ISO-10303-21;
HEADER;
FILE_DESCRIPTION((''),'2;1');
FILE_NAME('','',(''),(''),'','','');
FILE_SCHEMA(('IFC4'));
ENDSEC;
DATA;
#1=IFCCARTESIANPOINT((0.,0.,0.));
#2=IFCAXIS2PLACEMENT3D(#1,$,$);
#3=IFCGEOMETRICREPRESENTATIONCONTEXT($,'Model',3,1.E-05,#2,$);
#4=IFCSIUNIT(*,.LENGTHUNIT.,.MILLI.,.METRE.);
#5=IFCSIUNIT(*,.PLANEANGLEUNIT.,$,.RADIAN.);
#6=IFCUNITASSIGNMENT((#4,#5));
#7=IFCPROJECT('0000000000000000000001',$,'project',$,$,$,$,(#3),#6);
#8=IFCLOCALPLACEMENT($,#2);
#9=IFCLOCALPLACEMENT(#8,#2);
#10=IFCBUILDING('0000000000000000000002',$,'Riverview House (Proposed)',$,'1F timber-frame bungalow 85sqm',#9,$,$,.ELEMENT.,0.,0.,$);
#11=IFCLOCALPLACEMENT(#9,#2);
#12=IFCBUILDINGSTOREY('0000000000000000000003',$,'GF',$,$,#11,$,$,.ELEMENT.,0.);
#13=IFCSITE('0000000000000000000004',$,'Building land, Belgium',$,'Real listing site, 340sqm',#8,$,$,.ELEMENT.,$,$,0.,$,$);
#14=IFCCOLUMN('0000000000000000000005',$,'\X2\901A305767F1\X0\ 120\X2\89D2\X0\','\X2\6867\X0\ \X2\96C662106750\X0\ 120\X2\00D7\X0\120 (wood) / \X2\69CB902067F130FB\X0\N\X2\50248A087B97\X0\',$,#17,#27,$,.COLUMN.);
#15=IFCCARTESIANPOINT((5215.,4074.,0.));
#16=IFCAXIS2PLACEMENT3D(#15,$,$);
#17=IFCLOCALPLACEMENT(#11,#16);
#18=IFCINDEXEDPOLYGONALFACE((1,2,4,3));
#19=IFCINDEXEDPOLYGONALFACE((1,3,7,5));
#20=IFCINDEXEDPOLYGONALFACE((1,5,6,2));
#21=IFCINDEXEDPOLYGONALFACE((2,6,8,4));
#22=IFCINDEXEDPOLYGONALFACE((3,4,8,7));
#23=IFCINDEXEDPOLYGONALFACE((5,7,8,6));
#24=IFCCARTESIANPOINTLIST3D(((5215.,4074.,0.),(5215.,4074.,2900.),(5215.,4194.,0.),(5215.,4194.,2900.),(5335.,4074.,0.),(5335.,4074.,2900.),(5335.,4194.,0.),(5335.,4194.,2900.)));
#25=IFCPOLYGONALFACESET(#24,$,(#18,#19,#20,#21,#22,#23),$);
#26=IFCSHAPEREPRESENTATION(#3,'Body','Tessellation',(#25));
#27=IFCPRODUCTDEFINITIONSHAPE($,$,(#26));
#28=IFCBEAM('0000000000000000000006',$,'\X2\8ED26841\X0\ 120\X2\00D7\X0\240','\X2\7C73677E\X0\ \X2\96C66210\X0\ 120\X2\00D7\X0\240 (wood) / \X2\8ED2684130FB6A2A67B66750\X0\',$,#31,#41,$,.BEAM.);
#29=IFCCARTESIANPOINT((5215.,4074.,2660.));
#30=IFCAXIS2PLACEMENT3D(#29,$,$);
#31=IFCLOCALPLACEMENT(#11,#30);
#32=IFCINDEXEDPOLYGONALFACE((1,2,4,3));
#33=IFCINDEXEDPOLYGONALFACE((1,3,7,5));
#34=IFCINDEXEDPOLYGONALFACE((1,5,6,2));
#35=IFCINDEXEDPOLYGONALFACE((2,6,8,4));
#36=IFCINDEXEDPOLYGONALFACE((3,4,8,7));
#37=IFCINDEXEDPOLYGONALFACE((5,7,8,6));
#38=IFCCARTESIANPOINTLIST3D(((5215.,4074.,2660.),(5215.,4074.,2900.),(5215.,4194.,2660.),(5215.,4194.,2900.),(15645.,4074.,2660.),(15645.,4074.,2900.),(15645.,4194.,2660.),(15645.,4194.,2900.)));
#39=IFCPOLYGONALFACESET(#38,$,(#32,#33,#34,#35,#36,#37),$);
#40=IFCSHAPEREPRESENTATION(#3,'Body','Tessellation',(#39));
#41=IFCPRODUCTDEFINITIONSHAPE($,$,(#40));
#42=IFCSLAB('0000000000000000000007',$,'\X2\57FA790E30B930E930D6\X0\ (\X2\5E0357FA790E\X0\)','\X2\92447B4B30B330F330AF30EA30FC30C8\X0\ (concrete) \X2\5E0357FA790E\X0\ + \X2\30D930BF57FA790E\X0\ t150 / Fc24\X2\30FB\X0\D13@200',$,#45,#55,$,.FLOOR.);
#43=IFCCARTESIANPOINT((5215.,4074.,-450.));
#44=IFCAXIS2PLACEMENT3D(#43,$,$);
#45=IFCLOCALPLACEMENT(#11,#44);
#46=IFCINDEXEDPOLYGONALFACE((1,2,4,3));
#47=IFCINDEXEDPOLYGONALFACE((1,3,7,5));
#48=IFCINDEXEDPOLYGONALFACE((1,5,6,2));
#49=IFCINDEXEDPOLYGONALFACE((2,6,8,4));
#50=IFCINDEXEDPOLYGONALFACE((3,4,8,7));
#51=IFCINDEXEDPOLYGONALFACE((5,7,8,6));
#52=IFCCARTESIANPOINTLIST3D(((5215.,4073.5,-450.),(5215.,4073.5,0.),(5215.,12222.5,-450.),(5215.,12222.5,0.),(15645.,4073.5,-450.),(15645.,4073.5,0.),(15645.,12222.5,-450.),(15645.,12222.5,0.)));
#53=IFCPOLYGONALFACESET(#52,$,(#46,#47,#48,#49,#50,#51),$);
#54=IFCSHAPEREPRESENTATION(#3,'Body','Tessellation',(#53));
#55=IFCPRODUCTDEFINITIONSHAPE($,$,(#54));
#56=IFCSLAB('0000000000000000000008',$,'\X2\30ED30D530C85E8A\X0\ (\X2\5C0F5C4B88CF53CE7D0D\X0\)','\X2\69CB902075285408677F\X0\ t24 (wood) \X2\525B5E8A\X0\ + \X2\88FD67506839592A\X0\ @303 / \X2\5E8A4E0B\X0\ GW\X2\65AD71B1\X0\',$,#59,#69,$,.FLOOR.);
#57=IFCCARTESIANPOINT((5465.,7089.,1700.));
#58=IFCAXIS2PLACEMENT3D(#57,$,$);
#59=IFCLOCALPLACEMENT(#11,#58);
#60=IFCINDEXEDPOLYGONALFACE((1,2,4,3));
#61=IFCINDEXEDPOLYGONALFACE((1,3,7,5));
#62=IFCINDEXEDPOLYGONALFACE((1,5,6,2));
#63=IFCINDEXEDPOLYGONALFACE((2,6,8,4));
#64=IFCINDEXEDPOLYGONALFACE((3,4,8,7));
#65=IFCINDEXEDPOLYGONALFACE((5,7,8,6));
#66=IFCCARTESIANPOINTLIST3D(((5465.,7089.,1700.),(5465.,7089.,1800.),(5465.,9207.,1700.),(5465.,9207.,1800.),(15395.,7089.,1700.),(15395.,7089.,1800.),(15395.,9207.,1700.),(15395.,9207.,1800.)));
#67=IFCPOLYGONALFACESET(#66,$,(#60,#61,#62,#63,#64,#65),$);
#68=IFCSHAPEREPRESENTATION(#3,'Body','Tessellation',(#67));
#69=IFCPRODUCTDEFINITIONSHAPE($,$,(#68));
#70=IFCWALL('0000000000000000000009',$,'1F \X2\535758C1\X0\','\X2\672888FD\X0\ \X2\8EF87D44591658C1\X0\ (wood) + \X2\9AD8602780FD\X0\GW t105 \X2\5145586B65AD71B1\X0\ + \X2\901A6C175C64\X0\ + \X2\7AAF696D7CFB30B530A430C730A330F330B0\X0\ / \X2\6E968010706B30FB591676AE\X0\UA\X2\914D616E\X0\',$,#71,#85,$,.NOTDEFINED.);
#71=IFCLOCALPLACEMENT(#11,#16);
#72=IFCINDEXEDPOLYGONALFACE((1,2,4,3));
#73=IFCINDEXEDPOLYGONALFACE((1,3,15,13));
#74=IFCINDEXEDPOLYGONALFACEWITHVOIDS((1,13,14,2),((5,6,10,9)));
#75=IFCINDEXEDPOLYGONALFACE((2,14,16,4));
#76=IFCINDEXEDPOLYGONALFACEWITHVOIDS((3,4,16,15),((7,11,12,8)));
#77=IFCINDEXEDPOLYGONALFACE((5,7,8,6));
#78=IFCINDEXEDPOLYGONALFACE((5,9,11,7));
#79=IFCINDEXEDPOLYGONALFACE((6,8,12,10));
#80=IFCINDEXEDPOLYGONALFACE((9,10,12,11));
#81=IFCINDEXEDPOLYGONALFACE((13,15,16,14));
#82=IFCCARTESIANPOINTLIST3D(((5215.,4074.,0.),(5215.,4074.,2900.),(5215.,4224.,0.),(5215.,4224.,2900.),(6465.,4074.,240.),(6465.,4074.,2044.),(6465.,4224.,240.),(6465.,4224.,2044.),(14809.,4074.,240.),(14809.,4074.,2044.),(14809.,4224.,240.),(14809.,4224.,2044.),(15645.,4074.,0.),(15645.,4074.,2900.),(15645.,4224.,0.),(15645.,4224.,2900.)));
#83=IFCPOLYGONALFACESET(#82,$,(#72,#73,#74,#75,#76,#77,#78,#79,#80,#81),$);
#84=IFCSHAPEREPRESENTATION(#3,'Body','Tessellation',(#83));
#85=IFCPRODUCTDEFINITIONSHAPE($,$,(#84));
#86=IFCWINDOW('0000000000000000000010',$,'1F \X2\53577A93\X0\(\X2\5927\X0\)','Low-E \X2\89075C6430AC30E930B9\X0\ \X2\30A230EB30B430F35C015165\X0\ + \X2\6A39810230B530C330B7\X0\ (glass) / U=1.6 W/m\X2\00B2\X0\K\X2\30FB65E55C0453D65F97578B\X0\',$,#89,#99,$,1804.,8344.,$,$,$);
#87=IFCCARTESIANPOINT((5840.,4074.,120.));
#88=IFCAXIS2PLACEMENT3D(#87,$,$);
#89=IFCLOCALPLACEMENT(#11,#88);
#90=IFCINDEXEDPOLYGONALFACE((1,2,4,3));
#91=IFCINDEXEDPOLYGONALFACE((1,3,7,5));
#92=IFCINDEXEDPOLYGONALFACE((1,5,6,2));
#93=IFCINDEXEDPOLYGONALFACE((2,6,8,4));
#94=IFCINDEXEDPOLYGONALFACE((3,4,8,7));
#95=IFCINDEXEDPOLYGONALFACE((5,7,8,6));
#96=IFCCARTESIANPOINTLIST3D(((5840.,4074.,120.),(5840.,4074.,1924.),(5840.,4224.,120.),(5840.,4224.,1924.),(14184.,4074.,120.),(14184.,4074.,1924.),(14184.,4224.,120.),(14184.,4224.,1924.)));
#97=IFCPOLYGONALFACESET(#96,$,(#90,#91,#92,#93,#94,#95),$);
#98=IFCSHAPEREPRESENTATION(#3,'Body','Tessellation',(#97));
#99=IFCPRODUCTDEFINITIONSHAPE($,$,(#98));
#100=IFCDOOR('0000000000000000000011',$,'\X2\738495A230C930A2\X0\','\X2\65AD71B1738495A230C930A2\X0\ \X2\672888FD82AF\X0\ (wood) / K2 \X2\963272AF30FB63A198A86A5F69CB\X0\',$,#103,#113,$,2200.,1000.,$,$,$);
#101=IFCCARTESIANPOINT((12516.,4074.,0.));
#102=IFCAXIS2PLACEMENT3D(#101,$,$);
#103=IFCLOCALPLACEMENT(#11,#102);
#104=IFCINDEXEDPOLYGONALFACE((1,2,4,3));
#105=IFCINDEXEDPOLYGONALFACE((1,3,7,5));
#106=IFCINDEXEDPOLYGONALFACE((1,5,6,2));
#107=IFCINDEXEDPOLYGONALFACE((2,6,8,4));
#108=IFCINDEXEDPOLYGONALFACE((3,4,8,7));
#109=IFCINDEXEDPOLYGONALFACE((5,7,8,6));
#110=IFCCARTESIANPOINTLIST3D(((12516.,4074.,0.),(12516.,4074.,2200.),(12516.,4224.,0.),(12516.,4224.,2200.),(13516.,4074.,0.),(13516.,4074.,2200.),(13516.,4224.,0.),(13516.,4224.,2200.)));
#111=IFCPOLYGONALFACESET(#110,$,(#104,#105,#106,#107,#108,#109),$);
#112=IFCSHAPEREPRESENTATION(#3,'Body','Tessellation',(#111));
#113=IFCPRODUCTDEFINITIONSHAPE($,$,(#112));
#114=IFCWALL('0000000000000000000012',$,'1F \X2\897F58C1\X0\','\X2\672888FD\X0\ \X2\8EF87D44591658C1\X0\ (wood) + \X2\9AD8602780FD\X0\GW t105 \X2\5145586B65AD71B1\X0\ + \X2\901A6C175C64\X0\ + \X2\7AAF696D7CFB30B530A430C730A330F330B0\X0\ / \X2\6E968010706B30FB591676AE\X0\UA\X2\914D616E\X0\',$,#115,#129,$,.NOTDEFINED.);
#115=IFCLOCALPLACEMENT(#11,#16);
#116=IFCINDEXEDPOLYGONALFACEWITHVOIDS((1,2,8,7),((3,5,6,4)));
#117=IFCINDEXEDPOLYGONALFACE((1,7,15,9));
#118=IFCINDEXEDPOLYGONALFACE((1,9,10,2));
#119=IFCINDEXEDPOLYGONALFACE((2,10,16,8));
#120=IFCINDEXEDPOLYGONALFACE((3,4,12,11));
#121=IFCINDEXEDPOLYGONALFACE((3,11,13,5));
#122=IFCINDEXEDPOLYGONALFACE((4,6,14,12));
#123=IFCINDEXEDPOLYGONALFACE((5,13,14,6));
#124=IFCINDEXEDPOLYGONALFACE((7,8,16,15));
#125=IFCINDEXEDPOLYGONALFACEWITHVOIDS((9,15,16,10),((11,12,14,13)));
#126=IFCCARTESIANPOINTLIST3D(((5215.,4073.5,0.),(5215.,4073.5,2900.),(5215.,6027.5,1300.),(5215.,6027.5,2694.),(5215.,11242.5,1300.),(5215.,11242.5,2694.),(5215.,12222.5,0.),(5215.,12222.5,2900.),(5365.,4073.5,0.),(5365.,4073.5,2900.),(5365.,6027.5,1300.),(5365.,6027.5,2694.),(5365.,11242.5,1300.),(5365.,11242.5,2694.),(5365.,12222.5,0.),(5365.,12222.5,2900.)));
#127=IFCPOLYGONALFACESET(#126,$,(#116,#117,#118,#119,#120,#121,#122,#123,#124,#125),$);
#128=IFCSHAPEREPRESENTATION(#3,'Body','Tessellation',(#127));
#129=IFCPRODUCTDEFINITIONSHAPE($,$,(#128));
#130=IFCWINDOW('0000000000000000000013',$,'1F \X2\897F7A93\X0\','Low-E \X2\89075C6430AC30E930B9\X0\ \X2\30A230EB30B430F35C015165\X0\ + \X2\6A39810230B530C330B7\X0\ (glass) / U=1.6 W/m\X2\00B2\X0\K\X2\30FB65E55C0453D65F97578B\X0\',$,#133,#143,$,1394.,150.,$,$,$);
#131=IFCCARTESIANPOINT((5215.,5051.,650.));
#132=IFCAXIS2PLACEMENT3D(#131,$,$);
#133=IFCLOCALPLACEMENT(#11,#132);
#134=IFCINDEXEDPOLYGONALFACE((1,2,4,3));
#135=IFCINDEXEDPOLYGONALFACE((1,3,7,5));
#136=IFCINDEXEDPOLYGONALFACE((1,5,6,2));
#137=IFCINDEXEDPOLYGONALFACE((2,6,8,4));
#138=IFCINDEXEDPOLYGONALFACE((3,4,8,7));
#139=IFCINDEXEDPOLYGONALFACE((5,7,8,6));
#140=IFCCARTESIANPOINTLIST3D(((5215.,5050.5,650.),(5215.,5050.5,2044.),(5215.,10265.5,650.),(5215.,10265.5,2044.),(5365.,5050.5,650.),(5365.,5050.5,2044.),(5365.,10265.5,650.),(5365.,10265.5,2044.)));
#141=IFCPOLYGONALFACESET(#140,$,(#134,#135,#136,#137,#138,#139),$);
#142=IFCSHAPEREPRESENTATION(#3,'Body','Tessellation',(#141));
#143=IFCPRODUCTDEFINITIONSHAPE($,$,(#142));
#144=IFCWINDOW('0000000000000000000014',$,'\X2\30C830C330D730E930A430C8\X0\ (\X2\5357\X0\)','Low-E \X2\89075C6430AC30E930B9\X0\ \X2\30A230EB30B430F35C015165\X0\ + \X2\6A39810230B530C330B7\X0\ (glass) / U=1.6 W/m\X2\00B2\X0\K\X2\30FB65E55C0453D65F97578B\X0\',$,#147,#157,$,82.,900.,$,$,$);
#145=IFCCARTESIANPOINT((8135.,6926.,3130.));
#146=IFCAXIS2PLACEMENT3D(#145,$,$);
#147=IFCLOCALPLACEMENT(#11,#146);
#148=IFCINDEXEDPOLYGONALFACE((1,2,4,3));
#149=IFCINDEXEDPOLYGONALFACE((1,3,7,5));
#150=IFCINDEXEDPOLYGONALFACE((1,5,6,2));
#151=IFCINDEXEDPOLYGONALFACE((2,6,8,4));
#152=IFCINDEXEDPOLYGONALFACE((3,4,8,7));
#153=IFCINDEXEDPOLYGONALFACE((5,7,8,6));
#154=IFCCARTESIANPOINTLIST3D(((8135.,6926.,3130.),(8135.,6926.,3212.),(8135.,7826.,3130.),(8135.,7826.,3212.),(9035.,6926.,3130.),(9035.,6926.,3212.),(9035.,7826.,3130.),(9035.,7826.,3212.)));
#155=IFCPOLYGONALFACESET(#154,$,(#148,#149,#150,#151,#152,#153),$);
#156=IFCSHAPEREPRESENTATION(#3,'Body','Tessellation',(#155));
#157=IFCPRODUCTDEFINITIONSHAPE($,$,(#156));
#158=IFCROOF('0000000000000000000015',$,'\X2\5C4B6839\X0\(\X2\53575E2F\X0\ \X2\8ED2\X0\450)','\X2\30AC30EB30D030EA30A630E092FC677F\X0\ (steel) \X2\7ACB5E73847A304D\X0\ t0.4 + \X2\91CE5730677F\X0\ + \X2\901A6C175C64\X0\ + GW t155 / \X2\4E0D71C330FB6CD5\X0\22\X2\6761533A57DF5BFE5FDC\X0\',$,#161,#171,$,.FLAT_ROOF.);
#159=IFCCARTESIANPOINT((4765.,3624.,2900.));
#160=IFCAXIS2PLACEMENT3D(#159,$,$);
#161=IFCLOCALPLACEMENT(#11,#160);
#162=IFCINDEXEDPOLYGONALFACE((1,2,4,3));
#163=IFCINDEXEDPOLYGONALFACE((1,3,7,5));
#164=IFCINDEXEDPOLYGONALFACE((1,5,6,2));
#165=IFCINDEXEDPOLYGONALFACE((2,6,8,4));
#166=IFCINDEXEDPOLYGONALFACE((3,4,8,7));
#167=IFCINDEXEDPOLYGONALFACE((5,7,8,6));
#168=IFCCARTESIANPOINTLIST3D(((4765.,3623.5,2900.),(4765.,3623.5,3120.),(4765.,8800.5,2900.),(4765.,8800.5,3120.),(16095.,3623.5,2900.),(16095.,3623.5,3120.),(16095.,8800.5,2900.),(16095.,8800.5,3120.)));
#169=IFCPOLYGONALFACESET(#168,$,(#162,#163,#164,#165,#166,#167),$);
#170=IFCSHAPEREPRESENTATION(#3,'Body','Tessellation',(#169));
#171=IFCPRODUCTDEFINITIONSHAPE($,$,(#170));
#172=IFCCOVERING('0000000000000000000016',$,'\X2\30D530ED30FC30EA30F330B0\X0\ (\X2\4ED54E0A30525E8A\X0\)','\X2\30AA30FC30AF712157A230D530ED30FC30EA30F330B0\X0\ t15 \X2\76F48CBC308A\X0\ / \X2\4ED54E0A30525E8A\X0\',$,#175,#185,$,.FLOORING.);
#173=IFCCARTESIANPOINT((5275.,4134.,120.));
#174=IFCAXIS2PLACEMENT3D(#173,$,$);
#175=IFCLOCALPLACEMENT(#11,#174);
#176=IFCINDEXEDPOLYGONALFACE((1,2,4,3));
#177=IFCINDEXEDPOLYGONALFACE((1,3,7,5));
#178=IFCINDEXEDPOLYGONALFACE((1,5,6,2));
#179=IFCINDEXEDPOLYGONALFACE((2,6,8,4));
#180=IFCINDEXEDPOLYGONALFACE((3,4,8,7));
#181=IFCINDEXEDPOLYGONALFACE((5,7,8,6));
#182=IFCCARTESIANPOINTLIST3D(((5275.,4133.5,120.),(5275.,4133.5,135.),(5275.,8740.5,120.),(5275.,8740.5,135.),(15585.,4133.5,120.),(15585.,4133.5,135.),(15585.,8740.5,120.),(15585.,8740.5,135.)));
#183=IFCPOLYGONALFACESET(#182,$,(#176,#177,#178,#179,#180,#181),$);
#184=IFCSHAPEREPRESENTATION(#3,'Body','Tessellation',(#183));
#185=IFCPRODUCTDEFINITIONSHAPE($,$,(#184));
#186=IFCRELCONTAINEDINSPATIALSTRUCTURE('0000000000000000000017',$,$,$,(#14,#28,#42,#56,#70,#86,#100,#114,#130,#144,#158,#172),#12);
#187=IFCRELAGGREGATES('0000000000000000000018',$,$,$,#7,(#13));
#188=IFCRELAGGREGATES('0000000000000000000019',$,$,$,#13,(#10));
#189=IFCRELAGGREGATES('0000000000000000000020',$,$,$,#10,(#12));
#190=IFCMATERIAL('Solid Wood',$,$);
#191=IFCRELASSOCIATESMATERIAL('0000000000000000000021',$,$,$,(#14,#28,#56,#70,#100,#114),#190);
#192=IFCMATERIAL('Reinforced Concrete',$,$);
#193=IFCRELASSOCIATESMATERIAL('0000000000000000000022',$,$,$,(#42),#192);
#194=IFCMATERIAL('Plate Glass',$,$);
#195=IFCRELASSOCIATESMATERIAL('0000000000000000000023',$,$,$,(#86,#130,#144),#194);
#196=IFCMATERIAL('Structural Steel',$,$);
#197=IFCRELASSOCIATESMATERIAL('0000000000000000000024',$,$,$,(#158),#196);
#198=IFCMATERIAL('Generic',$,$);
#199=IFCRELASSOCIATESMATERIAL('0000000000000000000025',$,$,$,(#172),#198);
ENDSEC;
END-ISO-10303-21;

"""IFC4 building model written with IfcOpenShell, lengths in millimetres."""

from ifc_helpers import new_model, si_unit, frame, frame_2d, origin, place, context, project, spatial, rectangle, extrude, material, element, fill, save


model = new_model("IFC4")

# Units and contexts
model_context = context("Model", 3, precision=1e-05, world=origin())
ifc_project = project(units=[si_unit("LENGTHUNIT", "METRE", prefix="MILLI"), si_unit("PLANEANGLEUNIT", "RADIAN")], contexts=[model_context])

# Site, building, storey
site_placement = place(None, origin())
site = spatial("IfcSite", under=ifc_project, at=site_placement, Name="Building land, Belgium", ObjectType="Real listing site, 340sqm", CompositionType="ELEMENT", RefElevation=0.0)
building_placement = place(site_placement, origin())
building = spatial("IfcBuilding", under=site, at=building_placement, Name="Riverview House (Proposed)", ObjectType="1F timber-frame bungalow 85sqm", CompositionType="ELEMENT", ElevationOfRefHeight=0.0, ElevationOfTerrain=0.0)
storey_placement = place(building_placement, origin())
storey = spatial("IfcBuildingStorey", under=building, at=storey_placement, Name="GF", CompositionType="ELEMENT", Elevation=0.0)

# Column
ifc_material_1 = material(Name="Solid Wood")
column_1_placement = place(storey_placement, frame((5215.0, 4074.0, 0.0)))
element("IfcColumn", 1, at=column_1_placement, inside=storey, material=ifc_material_1, Name="通し柱 120角", Description="桧 集成材 120×120 (wood) / 構造柱・N値計算", PredefinedType="COLUMN", context=model_context, shape_type="SweptSolid", body=[
    extrude(rectangle(XDim=120.0, YDim=120.0, at=frame_2d((60.0, 60.0))), frame((5215.0, 4074.0, 0.0)), (0.0, 0.0, 1.0), 2900.0),
])

# Beam
beam_1_placement = place(storey_placement, frame((5215.0, 4074.0, 2660.0)))
element("IfcBeam", 2, at=beam_1_placement, inside=storey, material=ifc_material_1, Name="軒桁 120×240", Description="米松 集成 120×240 (wood) / 軒桁・横架材", PredefinedType="BEAM", context=model_context, shape_type="SweptSolid", body=[
    extrude(rectangle(XDim=10430.0, YDim=120.0, at=frame_2d((5215.0, 60.0))), frame((5215.0, 4074.0, 2660.0)), (0.0, 0.0, 1.0), 240.0),
])

# Slabs
ifc_material_2 = material(Name="Reinforced Concrete")
slab_1_placement = place(storey_placement, frame((5215.0, 4074.0, -450.0)))
element("IfcSlab", 3, at=slab_1_placement, inside=storey, material=ifc_material_2, Name="基礎スラブ (布基礎)", Description="鉄筋コンクリート (concrete) 布基礎 + ベタ基礎 t150 / Fc24・D13@200", PredefinedType="FLOOR", context=model_context, shape_type="SweptSolid", body=[
    extrude(rectangle(XDim=10430.0, YDim=8149.0, at=frame_2d((5215.0, 4074.0))), frame((5215.0, 4074.0, -450.0)), (0.0, 0.0, 1.0), 450.0),
])
slab_2_placement = place(storey_placement, frame((5465.0, 7089.0, 1700.0)))
element("IfcSlab", 4, at=slab_2_placement, inside=storey, material=ifc_material_1, Name="ロフト床 (小屋裏収納)", Description="構造用合板 t24 (wood) 剛床 + 製材根太 @303 / 床下 GW断熱", PredefinedType="FLOOR", context=model_context, shape_type="SweptSolid", body=[
    extrude(rectangle(XDim=9930.0, YDim=2118.0, at=frame_2d((4965.0, 1059.0))), frame((5465.0, 7089.0, 1700.0)), (0.0, 0.0, 1.0), 100.0),
])

# Wall, openings, window, door
wall_1_placement = place(storey_placement, frame((5215.0, 4074.0, 0.0)))
wall_1 = element("IfcWall", 5, at=wall_1_placement, inside=storey, material=ifc_material_1, Name="1F 南壁", Description="木製 軸組外壁 (wood) + 高性能GW t105 充填断熱 + 通気層 + 窯業系サイディング / 準耐火・外皮UA配慮", PredefinedType="NOTDEFINED", context=model_context, shape_type="SweptSolid", body=[
    extrude(rectangle(XDim=10430.0, YDim=150.0, at=frame_2d((5215.0, 75.0))), frame((5215.0, 4074.0, 0.0)), (0.0, 0.0, 1.0), 2900.0),
])
opening_1_placement = place(storey_placement, frame((5840.0, 4074.0, 120.0)))
opening_1 = element("IfcOpeningElement", 6, at=opening_1_placement, cuts=wall_1, PredefinedType="NOTDEFINED", context=model_context, shape_type="SweptSolid", body=[
    extrude(rectangle(XDim=8344.0, YDim=150.0, at=frame_2d((4172.0, 75.0))), frame((5840.0, 4074.0, 120.0)), (0.0, 0.0, 1.0), 1804.0),
])
opening_2_placement = place(storey_placement, frame((12516.0, 4074.0, 0.0)))
opening_2 = element("IfcOpeningElement", 7, at=opening_2_placement, cuts=wall_1, PredefinedType="NOTDEFINED", context=model_context, shape_type="SweptSolid", body=[
    extrude(rectangle(XDim=1000.0, YDim=150.0, at=frame_2d((500.0, 75.0))), frame((12516.0, 4074.0, 0.0)), (0.0, 0.0, 1.0), 2200.0),
])
ifc_material_3 = material(Name="Plate Glass")
window_1_placement = place(storey_placement, frame((5840.0, 4074.0, 120.0)))
window_1 = element("IfcWindow", 8, at=window_1_placement, inside=storey, material=ifc_material_3, Name="1F 南窓(大)", Description="Low-E 複層ガラス アルゴン封入 + 樹脂サッシ (glass) / U=1.6 W/m²K・日射取得型", OverallHeight=1804.0, OverallWidth=8344.0, context=model_context, shape_type="SweptSolid", body=[
    extrude(rectangle(XDim=8344.0, YDim=150.0, at=frame_2d((4172.0, 75.0))), frame((5840.0, 4074.0, 120.0)), (0.0, 0.0, 1.0), 1804.0),
])
fill(opening_1, window_1)
door_placement = place(storey_placement, frame((12516.0, 4074.0, 0.0)))
door = element("IfcDoor", 9, at=door_placement, inside=storey, material=ifc_material_1, Name="玄関ドア", Description="断熱玄関ドア 木製芯 (wood) / K2 防犯・採風機構", OverallHeight=2200.0, OverallWidth=1000.0, context=model_context, shape_type="SweptSolid", body=[
    extrude(rectangle(XDim=1000.0, YDim=150.0, at=frame_2d((500.0, 75.0))), frame((12516.0, 4074.0, 0.0)), (0.0, 0.0, 1.0), 2200.0),
])
fill(opening_2, door)

# Wall, opening, window
wall_2_placement = place(storey_placement, frame((5215.0, 4074.0, 0.0)))
wall_2 = element("IfcWall", 10, at=wall_2_placement, inside=storey, material=ifc_material_1, Name="1F 西壁", Description="木製 軸組外壁 (wood) + 高性能GW t105 充填断熱 + 通気層 + 窯業系サイディング / 準耐火・外皮UA配慮", PredefinedType="NOTDEFINED", context=model_context, shape_type="SweptSolid", body=[
    extrude(rectangle(XDim=150.0, YDim=8149.0, at=frame_2d((75.0, 4074.0))), frame((5215.0, 4074.0, 0.0)), (0.0, 0.0, 1.0), 2900.0),
])
opening_3_placement = place(storey_placement, frame((5215.0, 5051.0, 650.0)))
opening_3 = element("IfcOpeningElement", 11, at=opening_3_placement, cuts=wall_2, PredefinedType="NOTDEFINED", context=model_context, shape_type="SweptSolid", body=[
    extrude(rectangle(XDim=150.0, YDim=5215.0, at=frame_2d((75.0, 2607.0))), frame((5215.0, 5051.0, 650.0)), (0.0, 0.0, 1.0), 1394.0),
])
window_2_placement = place(storey_placement, frame((5215.0, 5051.0, 650.0)))
window_2 = element("IfcWindow", 12, at=window_2_placement, inside=storey, material=ifc_material_3, Name="1F 西窓", Description="Low-E 複層ガラス アルゴン封入 + 樹脂サッシ (glass) / U=1.6 W/m²K・日射取得型", OverallHeight=1394.0, OverallWidth=150.0, context=model_context, shape_type="SweptSolid", body=[
    extrude(rectangle(XDim=150.0, YDim=5215.0, at=frame_2d((75.0, 2607.0))), frame((5215.0, 5051.0, 650.0)), (0.0, 0.0, 1.0), 1394.0),
])
fill(opening_3, window_2)

# Window
window_3_placement = place(storey_placement, frame((8135.0, 6926.0, 3130.0)))
element("IfcWindow", 13, at=window_3_placement, inside=storey, material=ifc_material_3, Name="トップライト (南)", Description="Low-E 複層ガラス アルゴン封入 + 樹脂サッシ (glass) / U=1.6 W/m²K・日射取得型", OverallHeight=82.0, OverallWidth=900.0, context=model_context, shape_type="SweptSolid", body=[
    extrude(rectangle(XDim=900.0, YDim=900.0, at=frame_2d((450.0, 450.0))), frame((8135.0, 6926.0, 3130.0)), (0.0, 0.0, 1.0), 82.0),
])

# Roof
ifc_material_4 = material(Name="Structural Steel")
roof_placement = place(storey_placement, frame((4765.0, 3624.0, 2900.0)))
element("IfcRoof", 14, at=roof_placement, inside=storey, material=ifc_material_4, Name="屋根(南帯 軒450)", Description="ガルバリウム鋼板 (steel) 立平葺き t0.4 + 野地板 + 通気層 + GW t155 / 不燃・法22条区域対応", PredefinedType="FLAT_ROOF", context=model_context, shape_type="SweptSolid", body=[
    extrude(rectangle(XDim=11330.0, YDim=5177.0, at=frame_2d((5665.0, 2588.0))), frame((4765.0, 3624.0, 2900.0)), (0.0, 0.0, 1.0), 220.0),
])

# Covering
ifc_material_5 = material(Name="Generic")
covering_1_placement = place(storey_placement, frame((5275.0, 4134.0, 120.0)))
element("IfcCovering", 15, at=covering_1_placement, inside=storey, material=ifc_material_5, Name="フローリング (仕上げ床)", Description="オーク無垢フローリング t15 直貼り / 仕上げ床", PredefinedType="FLOORING", context=model_context, shape_type="SweptSolid", body=[
    extrude(rectangle(XDim=10310.0, YDim=4607.0, at=frame_2d((5155.0, 2303.0))), frame((5275.0, 4134.0, 120.0)), (0.0, 0.0, 1.0), 15.0),
])

save(model, "model.ifc")
